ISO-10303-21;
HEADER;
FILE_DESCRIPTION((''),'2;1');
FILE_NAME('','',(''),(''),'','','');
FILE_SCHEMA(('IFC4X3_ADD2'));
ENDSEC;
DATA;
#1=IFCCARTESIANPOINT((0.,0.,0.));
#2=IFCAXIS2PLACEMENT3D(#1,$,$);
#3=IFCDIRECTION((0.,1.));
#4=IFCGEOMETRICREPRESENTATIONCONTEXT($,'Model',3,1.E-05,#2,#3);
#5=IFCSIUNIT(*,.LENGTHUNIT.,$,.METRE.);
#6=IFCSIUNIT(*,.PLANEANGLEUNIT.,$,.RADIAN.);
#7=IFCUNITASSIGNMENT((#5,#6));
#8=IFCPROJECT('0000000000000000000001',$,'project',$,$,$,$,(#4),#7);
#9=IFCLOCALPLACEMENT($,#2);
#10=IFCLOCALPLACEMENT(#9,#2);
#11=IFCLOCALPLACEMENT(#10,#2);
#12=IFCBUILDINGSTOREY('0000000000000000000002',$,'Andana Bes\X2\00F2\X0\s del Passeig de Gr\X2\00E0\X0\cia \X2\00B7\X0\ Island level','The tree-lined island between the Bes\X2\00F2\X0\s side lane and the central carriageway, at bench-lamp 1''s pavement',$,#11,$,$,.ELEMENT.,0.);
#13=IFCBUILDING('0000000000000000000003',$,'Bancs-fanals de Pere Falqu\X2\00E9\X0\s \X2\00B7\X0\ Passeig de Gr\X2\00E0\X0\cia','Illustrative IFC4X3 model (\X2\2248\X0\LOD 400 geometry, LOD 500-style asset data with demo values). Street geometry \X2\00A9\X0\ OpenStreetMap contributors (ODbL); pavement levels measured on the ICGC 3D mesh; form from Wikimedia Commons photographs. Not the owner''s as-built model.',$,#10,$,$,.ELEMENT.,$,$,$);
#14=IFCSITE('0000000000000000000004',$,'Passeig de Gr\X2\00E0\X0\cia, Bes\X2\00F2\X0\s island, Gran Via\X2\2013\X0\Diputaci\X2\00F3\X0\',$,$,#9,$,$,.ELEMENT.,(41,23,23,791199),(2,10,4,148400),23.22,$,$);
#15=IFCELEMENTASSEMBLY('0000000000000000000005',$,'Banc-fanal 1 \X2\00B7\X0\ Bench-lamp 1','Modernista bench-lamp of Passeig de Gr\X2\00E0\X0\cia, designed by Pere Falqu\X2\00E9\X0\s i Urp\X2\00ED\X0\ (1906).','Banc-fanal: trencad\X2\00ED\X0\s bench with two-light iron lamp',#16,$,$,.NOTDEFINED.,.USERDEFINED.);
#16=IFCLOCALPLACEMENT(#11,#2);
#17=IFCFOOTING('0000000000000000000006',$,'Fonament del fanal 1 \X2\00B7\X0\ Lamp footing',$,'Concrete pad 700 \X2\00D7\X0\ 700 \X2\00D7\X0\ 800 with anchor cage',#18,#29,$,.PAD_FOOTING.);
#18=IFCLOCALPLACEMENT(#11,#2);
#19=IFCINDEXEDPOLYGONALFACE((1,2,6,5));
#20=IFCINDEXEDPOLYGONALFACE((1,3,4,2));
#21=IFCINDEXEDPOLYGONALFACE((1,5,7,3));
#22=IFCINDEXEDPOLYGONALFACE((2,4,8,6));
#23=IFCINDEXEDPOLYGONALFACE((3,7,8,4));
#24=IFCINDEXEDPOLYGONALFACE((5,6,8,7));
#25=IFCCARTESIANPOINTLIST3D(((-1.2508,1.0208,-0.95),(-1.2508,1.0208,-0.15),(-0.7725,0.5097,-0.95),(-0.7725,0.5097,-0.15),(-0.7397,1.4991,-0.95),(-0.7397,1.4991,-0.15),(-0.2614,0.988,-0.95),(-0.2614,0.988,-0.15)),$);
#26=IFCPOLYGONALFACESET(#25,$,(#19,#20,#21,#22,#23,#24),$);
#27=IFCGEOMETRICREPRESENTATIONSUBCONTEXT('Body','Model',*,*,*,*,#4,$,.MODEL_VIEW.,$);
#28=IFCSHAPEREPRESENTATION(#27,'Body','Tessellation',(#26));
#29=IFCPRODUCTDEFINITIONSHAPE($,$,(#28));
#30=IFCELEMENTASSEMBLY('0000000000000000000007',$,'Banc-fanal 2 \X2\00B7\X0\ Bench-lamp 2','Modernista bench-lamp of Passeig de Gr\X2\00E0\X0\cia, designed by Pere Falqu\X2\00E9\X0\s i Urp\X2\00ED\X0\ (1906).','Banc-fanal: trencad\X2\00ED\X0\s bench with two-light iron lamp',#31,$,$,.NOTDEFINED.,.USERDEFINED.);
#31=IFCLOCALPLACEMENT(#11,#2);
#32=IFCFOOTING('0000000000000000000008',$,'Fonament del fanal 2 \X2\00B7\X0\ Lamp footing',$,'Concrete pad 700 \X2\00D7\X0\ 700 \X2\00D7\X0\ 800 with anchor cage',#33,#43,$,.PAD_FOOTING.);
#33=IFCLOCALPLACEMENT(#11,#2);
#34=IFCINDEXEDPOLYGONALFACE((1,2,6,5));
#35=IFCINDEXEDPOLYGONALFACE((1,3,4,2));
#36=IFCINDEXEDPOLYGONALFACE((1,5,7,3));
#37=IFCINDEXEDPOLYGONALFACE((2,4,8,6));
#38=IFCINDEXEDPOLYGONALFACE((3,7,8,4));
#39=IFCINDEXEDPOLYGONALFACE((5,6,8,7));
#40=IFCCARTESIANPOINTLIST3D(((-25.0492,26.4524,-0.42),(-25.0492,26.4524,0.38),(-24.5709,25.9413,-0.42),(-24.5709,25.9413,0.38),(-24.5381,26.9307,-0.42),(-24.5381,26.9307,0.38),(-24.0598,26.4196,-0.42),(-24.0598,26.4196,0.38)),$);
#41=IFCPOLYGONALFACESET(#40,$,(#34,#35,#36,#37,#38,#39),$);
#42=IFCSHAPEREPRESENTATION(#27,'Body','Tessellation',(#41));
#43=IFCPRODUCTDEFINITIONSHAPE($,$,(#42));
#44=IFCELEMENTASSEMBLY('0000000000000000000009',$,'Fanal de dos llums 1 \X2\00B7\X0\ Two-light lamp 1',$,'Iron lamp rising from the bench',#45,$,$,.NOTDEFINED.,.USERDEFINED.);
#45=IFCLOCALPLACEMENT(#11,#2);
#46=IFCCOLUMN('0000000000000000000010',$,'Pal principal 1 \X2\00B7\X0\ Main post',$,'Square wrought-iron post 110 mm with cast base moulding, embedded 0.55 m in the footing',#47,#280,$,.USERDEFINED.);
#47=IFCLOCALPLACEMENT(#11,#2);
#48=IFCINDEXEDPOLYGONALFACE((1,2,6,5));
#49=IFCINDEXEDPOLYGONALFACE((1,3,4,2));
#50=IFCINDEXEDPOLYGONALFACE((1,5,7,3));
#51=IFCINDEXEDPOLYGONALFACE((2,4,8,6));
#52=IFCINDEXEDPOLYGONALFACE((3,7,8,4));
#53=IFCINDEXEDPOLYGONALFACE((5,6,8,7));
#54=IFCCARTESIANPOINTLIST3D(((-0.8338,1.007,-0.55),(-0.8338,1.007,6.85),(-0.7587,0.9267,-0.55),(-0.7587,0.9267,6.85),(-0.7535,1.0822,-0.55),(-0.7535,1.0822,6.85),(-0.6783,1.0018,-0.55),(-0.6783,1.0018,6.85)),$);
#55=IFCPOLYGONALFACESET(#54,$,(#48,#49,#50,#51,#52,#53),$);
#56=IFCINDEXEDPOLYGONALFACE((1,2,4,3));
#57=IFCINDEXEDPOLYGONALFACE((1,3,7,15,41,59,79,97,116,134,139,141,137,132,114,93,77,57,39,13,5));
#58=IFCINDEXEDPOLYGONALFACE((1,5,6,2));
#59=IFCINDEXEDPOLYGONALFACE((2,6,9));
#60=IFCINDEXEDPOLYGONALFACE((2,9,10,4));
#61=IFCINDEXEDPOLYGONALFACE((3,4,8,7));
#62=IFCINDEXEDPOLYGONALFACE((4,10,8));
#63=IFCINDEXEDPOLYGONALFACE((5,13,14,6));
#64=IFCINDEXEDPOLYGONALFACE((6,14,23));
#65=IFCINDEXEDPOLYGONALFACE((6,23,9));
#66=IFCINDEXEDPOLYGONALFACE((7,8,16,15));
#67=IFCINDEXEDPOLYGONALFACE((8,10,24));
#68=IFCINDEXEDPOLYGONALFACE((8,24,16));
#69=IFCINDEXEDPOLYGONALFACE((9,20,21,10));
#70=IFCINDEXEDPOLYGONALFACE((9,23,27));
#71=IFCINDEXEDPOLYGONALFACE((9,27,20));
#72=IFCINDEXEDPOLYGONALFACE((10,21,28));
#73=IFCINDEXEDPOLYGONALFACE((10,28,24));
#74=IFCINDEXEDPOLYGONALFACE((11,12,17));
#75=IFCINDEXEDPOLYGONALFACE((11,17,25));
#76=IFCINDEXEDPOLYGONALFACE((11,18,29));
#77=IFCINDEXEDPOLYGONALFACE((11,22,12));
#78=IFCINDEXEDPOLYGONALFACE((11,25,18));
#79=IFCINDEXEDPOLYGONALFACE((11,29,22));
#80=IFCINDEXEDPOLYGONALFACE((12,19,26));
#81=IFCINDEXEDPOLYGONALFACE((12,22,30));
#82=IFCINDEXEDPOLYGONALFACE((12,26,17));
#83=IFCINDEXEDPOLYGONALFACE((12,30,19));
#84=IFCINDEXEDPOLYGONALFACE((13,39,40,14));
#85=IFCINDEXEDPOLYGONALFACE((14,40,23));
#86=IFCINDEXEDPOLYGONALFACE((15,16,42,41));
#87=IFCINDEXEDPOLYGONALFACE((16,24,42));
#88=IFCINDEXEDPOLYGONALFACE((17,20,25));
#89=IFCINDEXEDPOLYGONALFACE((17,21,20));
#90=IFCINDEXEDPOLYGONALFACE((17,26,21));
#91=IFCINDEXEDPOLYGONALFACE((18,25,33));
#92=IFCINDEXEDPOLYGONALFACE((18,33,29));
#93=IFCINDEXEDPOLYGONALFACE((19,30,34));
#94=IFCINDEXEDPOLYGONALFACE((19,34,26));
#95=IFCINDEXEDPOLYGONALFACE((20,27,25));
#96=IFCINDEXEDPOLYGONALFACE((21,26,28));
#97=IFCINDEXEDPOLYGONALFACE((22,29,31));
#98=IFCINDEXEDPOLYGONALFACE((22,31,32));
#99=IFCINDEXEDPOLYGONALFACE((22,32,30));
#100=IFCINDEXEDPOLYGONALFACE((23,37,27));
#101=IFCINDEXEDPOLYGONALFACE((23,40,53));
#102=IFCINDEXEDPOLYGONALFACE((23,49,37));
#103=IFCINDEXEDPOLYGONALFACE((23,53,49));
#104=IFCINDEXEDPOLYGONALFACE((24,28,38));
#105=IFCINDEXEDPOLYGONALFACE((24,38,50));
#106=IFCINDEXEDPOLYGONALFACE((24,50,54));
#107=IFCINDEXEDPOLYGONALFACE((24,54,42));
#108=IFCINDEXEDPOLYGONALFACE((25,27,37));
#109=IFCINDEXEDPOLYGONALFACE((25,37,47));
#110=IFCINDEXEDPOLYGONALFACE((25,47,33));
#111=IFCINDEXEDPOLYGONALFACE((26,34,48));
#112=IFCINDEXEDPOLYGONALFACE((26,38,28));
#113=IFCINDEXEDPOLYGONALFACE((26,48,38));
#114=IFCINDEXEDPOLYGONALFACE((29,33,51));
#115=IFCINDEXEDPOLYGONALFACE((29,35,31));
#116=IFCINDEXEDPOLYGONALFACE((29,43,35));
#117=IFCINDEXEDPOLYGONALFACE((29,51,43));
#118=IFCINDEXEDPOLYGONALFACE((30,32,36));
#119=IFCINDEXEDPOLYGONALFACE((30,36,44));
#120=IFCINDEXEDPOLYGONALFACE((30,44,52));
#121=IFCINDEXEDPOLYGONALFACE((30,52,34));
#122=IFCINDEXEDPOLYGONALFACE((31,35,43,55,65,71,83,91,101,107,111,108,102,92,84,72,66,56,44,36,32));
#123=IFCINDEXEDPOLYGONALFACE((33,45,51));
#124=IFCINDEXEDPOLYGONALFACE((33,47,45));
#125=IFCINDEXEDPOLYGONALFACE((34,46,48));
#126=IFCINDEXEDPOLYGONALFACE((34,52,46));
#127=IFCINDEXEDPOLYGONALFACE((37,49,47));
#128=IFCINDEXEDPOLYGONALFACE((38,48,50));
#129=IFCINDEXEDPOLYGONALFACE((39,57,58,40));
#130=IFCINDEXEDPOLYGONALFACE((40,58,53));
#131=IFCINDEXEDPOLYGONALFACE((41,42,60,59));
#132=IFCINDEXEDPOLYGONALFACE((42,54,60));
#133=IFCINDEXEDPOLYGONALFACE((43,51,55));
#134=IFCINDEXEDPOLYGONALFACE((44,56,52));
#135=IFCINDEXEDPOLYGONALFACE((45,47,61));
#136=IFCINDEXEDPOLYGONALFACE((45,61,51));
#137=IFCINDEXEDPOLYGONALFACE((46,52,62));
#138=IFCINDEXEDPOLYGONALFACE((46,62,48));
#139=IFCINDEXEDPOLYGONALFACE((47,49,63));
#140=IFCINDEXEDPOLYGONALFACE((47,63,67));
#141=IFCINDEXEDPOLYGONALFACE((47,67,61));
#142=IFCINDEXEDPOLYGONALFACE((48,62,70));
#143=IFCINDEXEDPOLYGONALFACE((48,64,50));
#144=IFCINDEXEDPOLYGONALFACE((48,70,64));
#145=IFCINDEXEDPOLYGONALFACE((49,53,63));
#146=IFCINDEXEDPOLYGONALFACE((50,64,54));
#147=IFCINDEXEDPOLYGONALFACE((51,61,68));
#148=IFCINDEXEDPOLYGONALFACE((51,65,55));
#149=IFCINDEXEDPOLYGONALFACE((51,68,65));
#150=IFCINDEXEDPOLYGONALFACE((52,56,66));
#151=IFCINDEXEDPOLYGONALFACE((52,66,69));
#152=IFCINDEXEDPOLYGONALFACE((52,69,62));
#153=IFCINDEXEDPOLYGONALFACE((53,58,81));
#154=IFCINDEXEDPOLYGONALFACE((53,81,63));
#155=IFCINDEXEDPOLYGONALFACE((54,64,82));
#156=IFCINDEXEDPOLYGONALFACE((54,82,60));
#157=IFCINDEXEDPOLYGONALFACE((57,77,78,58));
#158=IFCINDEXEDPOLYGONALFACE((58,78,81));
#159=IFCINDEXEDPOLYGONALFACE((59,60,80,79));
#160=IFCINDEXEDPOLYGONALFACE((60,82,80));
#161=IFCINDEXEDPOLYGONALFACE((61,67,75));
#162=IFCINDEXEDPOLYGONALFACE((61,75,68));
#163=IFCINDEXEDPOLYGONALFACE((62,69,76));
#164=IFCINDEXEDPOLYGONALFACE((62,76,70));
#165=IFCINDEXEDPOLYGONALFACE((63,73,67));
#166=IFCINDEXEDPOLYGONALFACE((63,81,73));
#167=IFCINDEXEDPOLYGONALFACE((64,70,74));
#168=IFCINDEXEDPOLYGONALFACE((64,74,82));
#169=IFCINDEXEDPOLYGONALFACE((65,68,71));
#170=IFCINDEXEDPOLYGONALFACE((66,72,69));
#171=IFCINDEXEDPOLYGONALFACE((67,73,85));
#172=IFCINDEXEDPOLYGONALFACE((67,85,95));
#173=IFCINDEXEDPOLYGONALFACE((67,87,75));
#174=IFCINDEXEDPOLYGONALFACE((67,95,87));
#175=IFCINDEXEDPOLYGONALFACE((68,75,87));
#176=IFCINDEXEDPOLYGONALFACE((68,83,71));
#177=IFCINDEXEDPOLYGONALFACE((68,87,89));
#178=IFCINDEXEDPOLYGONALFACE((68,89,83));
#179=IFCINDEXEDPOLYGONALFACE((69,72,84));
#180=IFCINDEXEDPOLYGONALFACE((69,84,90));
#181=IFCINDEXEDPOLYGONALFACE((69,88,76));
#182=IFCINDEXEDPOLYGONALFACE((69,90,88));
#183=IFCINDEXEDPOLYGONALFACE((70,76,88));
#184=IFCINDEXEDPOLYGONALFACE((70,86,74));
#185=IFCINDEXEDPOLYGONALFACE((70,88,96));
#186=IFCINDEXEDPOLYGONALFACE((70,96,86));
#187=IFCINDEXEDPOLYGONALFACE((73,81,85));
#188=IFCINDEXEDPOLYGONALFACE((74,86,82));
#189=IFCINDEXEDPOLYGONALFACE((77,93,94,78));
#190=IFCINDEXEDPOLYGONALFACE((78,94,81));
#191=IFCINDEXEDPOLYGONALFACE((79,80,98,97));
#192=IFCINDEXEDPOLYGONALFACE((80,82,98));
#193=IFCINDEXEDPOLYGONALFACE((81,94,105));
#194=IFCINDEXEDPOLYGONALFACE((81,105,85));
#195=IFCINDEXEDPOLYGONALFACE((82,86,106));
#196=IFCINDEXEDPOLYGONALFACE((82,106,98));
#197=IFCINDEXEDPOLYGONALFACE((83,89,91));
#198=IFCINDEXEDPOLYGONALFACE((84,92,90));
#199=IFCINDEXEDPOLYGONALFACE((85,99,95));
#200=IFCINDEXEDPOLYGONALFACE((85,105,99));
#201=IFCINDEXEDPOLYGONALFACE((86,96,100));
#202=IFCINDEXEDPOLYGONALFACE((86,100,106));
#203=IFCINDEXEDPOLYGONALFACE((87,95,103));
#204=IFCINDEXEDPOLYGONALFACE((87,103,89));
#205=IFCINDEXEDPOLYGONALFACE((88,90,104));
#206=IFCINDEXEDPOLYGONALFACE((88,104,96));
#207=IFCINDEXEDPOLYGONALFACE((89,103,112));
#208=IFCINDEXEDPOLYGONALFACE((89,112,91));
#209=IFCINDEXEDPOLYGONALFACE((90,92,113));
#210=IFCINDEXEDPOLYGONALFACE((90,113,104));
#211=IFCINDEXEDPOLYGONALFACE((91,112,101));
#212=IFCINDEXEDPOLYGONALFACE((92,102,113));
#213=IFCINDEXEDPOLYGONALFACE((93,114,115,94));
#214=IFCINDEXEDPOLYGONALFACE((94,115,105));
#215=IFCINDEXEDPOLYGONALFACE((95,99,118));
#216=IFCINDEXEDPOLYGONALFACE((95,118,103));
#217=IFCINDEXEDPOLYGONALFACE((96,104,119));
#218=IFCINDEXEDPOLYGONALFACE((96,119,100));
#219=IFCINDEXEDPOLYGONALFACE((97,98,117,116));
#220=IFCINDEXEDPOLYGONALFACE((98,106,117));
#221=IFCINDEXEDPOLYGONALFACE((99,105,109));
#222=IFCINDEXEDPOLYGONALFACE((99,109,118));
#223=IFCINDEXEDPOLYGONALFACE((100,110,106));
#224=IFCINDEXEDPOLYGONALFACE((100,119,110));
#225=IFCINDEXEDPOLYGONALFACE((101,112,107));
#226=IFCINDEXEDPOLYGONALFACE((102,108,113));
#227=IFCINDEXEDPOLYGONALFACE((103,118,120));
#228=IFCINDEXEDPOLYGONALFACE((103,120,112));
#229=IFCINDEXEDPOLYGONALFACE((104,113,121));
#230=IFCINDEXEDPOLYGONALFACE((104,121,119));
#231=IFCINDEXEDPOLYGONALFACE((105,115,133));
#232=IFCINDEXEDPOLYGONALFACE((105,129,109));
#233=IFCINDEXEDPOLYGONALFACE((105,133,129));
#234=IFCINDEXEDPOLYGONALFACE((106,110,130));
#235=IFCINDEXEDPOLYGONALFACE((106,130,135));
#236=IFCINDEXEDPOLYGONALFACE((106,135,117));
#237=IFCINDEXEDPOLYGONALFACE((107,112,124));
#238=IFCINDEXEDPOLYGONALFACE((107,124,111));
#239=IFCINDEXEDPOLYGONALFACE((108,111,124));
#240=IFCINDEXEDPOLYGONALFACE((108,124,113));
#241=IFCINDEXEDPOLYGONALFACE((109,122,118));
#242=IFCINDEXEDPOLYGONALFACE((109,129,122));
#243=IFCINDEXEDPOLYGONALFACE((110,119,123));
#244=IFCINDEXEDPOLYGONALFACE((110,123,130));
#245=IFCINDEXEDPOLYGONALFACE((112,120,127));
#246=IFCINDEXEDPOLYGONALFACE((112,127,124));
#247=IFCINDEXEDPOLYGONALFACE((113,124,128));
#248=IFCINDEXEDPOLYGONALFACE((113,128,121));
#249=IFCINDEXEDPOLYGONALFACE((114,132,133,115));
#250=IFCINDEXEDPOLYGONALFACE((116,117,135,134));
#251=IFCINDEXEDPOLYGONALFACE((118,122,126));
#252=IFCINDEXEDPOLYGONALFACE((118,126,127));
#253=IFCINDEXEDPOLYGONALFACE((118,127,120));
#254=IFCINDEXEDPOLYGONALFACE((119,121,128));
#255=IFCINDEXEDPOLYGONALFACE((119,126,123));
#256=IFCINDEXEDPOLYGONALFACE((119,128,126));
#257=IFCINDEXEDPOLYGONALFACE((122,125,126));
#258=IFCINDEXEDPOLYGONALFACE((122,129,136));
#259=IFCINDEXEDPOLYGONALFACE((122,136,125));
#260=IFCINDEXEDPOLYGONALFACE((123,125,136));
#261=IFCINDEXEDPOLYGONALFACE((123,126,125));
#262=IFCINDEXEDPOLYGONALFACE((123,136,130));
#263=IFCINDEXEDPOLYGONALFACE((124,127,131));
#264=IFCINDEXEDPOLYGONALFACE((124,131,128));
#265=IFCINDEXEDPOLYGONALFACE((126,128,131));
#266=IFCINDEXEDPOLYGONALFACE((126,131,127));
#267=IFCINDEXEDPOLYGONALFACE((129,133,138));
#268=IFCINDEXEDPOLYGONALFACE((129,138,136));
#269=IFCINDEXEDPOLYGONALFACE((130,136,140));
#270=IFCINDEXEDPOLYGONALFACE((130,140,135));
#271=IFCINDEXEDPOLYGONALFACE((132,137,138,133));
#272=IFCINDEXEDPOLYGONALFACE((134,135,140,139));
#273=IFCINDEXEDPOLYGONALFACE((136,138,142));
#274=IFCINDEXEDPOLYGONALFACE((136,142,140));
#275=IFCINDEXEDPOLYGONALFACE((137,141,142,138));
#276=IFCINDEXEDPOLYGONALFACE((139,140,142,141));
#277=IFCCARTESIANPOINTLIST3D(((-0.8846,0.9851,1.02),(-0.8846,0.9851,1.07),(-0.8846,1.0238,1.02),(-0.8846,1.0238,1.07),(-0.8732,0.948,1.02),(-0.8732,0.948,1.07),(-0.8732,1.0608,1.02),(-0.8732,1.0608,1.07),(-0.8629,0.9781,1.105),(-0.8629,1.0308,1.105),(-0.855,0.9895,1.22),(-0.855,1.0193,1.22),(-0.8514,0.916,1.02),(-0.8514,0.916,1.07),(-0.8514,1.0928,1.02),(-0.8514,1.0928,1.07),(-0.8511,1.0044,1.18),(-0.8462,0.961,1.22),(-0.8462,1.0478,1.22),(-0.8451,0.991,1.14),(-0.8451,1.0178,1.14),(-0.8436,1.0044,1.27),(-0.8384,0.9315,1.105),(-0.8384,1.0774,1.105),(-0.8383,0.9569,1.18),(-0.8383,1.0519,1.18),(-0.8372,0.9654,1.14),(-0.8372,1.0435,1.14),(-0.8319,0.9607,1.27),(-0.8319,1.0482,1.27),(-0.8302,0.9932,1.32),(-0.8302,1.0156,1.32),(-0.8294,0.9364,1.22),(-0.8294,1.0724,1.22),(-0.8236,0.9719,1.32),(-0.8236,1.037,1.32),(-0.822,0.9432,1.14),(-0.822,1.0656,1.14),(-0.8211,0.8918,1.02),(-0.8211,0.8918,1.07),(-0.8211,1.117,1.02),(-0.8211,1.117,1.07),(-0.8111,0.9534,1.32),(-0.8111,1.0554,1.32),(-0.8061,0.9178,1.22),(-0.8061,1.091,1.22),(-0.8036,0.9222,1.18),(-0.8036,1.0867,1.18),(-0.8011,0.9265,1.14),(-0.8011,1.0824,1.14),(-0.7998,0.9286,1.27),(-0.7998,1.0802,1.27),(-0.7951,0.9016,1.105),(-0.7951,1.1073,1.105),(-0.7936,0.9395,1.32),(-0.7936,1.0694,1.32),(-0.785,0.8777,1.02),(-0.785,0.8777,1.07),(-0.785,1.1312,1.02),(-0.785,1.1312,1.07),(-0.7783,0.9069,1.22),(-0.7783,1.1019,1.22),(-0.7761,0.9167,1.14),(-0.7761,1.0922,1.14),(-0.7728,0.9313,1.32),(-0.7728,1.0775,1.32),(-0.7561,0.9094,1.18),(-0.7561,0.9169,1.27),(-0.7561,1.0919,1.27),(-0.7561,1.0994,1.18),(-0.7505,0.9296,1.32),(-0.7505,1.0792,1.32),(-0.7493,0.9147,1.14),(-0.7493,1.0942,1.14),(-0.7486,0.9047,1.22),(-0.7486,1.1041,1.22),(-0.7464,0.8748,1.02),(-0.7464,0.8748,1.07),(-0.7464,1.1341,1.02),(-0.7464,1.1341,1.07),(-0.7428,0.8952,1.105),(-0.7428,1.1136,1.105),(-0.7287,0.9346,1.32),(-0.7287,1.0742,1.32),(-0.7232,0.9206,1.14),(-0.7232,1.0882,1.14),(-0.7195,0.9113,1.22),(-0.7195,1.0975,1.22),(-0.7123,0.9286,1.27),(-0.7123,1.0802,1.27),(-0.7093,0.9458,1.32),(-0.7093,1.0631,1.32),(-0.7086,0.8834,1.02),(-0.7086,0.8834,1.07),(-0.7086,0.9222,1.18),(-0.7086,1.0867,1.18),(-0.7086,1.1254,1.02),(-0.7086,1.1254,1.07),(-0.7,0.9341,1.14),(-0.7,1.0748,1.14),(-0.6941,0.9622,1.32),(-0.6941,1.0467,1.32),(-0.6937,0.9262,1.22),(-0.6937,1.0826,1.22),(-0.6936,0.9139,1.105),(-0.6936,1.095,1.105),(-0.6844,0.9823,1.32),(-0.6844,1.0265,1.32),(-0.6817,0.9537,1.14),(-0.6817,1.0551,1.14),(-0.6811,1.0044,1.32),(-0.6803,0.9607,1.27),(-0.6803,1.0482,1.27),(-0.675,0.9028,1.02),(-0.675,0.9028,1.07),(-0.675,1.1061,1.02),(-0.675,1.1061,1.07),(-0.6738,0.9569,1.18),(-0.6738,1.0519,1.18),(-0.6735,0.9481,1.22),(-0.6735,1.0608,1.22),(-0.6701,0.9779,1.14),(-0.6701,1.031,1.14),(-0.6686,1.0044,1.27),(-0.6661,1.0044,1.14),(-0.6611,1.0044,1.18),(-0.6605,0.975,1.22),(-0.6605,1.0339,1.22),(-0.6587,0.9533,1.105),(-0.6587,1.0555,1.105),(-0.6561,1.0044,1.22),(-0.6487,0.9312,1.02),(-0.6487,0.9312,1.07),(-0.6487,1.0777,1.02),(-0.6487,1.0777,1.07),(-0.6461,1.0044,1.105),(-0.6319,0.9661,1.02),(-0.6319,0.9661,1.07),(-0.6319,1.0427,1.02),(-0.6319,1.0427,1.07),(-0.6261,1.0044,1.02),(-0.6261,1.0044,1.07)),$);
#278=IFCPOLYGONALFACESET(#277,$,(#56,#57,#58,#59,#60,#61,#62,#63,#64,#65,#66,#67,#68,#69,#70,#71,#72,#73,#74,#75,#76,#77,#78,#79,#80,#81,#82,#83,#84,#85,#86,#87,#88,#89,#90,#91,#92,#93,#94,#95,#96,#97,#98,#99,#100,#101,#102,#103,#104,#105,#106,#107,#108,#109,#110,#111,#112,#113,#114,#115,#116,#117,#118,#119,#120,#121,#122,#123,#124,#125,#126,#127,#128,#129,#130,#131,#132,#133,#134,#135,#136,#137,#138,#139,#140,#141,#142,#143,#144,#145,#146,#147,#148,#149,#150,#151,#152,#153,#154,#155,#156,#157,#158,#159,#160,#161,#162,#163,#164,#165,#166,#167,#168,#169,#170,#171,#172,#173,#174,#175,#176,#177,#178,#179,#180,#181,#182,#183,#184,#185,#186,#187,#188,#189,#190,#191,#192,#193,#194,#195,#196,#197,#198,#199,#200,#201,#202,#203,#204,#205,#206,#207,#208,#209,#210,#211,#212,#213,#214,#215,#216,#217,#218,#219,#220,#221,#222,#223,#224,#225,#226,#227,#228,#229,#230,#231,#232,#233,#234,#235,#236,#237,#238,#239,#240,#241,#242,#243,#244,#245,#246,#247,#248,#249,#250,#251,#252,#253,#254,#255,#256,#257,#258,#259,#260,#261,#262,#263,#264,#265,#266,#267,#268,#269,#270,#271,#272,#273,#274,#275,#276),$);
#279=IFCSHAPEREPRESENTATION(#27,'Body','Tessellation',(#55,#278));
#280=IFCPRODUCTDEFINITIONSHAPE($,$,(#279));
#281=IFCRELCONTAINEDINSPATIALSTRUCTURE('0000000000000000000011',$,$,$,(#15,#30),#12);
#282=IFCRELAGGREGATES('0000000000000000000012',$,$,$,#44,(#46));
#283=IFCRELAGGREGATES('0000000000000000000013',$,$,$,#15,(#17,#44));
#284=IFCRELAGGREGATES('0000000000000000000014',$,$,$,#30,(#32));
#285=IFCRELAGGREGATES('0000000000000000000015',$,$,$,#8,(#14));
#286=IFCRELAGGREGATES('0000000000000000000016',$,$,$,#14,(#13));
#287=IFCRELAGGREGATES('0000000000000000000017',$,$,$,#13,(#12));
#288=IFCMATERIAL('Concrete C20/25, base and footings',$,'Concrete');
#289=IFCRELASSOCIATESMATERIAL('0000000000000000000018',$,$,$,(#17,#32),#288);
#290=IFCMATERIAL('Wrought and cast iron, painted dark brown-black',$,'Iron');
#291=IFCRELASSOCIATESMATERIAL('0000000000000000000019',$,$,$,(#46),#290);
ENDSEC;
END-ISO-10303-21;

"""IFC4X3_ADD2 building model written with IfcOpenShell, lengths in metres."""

from ifc_helpers import new_model, entity, si_unit, direction, frame, frame_2d, origin, place, context, subcontext, project, spatial, rectangle, extrude, material, element, aggregate, save


model = new_model("IFC4X3_ADD2")

# Units and contexts
model_context = context("Model", 3, precision=1e-05, world=origin(), true_north=direction((0.0, 1.0)))
body_context = subcontext(model_context, "Body", "Model", "MODEL_VIEW")
ifc_project = project(units=[si_unit("LENGTHUNIT", "METRE"), si_unit("PLANEANGLEUNIT", "RADIAN")], contexts=[model_context])

# Site, building, storey
site_placement = place(None, origin())
site = spatial("IfcSite", under=ifc_project, at=site_placement, Name="Passeig de Gràcia, Besòs island, Gran Via–Diputació", CompositionType="ELEMENT", RefLatitude=(41, 23, 23, 791199), RefLongitude=(2, 10, 4, 148400), RefElevation=23.22)
building_placement = place(site_placement, origin())
building = spatial("IfcBuilding", under=site, at=building_placement, Name="Bancs-fanals de Pere Falqués · Passeig de Gràcia", Description="Illustrative IFC4X3 model (≈LOD 400 geometry, LOD 500-style asset data with demo values). Street geometry © OpenStreetMap contributors (ODbL); pavement levels measured on the ICGC 3D mesh; form from Wikimedia Commons photographs. Not the owner's as-built model.", CompositionType="ELEMENT")
storey_placement = place(building_placement, origin())
storey = spatial("IfcBuildingStorey", under=building, at=storey_placement, Name="Andana Besòs del Passeig de Gràcia · Island level", Description="The tree-lined island between the Besòs side lane and the central carriageway, at bench-lamp 1's pavement", CompositionType="ELEMENT", Elevation=0.0)

# Element assemblies, footings
assembly_1_placement = place(building_placement, origin())
assembly_1 = element("IfcElementAssembly", 1, at=assembly_1_placement, inside=storey, Name="Banc-fanal 1 · Bench-lamp 1", Description="Modernista bench-lamp of Passeig de Gràcia, designed by Pere Falqués i Urpí (1906).", ObjectType="Banc-fanal: trencadís bench with two-light iron lamp", AssemblyPlace="NOTDEFINED", PredefinedType="USERDEFINED")
ifc_material_1 = material(Name="Concrete C20/25, base and footings", Category="Concrete")
footing_1_placement = place(building_placement, origin())
footing_1 = element("IfcFooting", 2, at=footing_1_placement, material=ifc_material_1, Name="Fonament del fanal 1 · Lamp footing", ObjectType="Concrete pad 700 × 700 × 800 with anchor cage", PredefinedType="PAD_FOOTING", context=body_context, shape_type="SweptSolid", body=[
    extrude(rectangle(XDim=0.7, YDim=0.7, at=frame_2d((0.0, 0.0), x_axis=(-0.683274, 0.730162))), frame((-0.7561, 1.0044, -0.95)), (0.0, 0.0, 1.0), 0.8),
])
assembly_2_placement = place(building_placement, origin())
assembly_2 = element("IfcElementAssembly", 3, at=assembly_2_placement, inside=storey, Name="Banc-fanal 2 · Bench-lamp 2", Description="Modernista bench-lamp of Passeig de Gràcia, designed by Pere Falqués i Urpí (1906).", ObjectType="Banc-fanal: trencadís bench with two-light iron lamp", AssemblyPlace="NOTDEFINED", PredefinedType="USERDEFINED")
footing_2_placement = place(building_placement, origin())
footing_2 = element("IfcFooting", 4, at=footing_2_placement, material=ifc_material_1, Name="Fonament del fanal 2 · Lamp footing", ObjectType="Concrete pad 700 × 700 × 800 with anchor cage", PredefinedType="PAD_FOOTING", context=body_context, shape_type="SweptSolid", body=[
    extrude(rectangle(XDim=0.7, YDim=0.7, at=frame_2d((0.0, 0.0), x_axis=(-0.683274, 0.730162))), frame((-24.5545, 26.436, -0.42)), (0.0, 0.0, 1.0), 0.8),
])

# Element assembly, column
assembly_3_placement = place(building_placement, origin())
assembly_3 = element("IfcElementAssembly", 5, at=assembly_3_placement, Name="Fanal de dos llums 1 · Two-light lamp 1", ObjectType="Iron lamp rising from the bench", AssemblyPlace="NOTDEFINED", PredefinedType="USERDEFINED")
ifc_material_2 = material(Name="Wrought and cast iron, painted dark brown-black", Category="Iron")
column_1_placement = place(building_placement, origin())
column_1 = element("IfcColumn", 6, at=column_1_placement, material=ifc_material_2, Name="Pal principal 1 · Main post", ObjectType="Square wrought-iron post 110 mm with cast base moulding, embedded 0.55 m in the footing", PredefinedType="USERDEFINED", context=body_context, shape_type="SweptSolid", body=[
    extrude(rectangle(XDim=0.11, YDim=0.11, at=frame_2d((0.0, 0.0), x_axis=(-0.683274, 0.730162))), frame((-0.7561, 1.0044, -0.55)), (0.0, 0.0, 1.0), 7.4),
    entity("IfcRevolvedAreaSolid", entity("IfcArbitraryClosedProfileDef", "AREA", None, entity("IfcPolyline", [entity("IfcCartesianPoint", [0.0, 0.0]), entity("IfcCartesianPoint", [0.13, 0.0]), entity("IfcCartesianPoint", [0.13, 0.05]), entity("IfcCartesianPoint", [0.09, 0.12]), entity("IfcCartesianPoint", [0.1, 0.2]), entity("IfcCartesianPoint", [0.075, 0.3]), entity("IfcCartesianPoint", [0.0, 0.3]), entity("IfcCartesianPoint", [0.0, 0.0])])), entity("IfcAxis2Placement3D", entity("IfcCartesianPoint", [-0.7561, 1.0044, 1.02]), entity("IfcDirection", [0.0, -1.0, 0.0]), entity("IfcDirection", [1.0, 0.0, 0.0])), entity("IfcAxis1Placement", entity("IfcCartesianPoint", [0.0, 0.0, 0.0]), entity("IfcDirection", [0.0, 1.0, 0.0])), 6.283185),
])

aggregate(assembly_3, [column_1])

aggregate(assembly_1, [footing_1, assembly_3])
aggregate(assembly_2, [footing_2])

save(model, "model.ifc")
